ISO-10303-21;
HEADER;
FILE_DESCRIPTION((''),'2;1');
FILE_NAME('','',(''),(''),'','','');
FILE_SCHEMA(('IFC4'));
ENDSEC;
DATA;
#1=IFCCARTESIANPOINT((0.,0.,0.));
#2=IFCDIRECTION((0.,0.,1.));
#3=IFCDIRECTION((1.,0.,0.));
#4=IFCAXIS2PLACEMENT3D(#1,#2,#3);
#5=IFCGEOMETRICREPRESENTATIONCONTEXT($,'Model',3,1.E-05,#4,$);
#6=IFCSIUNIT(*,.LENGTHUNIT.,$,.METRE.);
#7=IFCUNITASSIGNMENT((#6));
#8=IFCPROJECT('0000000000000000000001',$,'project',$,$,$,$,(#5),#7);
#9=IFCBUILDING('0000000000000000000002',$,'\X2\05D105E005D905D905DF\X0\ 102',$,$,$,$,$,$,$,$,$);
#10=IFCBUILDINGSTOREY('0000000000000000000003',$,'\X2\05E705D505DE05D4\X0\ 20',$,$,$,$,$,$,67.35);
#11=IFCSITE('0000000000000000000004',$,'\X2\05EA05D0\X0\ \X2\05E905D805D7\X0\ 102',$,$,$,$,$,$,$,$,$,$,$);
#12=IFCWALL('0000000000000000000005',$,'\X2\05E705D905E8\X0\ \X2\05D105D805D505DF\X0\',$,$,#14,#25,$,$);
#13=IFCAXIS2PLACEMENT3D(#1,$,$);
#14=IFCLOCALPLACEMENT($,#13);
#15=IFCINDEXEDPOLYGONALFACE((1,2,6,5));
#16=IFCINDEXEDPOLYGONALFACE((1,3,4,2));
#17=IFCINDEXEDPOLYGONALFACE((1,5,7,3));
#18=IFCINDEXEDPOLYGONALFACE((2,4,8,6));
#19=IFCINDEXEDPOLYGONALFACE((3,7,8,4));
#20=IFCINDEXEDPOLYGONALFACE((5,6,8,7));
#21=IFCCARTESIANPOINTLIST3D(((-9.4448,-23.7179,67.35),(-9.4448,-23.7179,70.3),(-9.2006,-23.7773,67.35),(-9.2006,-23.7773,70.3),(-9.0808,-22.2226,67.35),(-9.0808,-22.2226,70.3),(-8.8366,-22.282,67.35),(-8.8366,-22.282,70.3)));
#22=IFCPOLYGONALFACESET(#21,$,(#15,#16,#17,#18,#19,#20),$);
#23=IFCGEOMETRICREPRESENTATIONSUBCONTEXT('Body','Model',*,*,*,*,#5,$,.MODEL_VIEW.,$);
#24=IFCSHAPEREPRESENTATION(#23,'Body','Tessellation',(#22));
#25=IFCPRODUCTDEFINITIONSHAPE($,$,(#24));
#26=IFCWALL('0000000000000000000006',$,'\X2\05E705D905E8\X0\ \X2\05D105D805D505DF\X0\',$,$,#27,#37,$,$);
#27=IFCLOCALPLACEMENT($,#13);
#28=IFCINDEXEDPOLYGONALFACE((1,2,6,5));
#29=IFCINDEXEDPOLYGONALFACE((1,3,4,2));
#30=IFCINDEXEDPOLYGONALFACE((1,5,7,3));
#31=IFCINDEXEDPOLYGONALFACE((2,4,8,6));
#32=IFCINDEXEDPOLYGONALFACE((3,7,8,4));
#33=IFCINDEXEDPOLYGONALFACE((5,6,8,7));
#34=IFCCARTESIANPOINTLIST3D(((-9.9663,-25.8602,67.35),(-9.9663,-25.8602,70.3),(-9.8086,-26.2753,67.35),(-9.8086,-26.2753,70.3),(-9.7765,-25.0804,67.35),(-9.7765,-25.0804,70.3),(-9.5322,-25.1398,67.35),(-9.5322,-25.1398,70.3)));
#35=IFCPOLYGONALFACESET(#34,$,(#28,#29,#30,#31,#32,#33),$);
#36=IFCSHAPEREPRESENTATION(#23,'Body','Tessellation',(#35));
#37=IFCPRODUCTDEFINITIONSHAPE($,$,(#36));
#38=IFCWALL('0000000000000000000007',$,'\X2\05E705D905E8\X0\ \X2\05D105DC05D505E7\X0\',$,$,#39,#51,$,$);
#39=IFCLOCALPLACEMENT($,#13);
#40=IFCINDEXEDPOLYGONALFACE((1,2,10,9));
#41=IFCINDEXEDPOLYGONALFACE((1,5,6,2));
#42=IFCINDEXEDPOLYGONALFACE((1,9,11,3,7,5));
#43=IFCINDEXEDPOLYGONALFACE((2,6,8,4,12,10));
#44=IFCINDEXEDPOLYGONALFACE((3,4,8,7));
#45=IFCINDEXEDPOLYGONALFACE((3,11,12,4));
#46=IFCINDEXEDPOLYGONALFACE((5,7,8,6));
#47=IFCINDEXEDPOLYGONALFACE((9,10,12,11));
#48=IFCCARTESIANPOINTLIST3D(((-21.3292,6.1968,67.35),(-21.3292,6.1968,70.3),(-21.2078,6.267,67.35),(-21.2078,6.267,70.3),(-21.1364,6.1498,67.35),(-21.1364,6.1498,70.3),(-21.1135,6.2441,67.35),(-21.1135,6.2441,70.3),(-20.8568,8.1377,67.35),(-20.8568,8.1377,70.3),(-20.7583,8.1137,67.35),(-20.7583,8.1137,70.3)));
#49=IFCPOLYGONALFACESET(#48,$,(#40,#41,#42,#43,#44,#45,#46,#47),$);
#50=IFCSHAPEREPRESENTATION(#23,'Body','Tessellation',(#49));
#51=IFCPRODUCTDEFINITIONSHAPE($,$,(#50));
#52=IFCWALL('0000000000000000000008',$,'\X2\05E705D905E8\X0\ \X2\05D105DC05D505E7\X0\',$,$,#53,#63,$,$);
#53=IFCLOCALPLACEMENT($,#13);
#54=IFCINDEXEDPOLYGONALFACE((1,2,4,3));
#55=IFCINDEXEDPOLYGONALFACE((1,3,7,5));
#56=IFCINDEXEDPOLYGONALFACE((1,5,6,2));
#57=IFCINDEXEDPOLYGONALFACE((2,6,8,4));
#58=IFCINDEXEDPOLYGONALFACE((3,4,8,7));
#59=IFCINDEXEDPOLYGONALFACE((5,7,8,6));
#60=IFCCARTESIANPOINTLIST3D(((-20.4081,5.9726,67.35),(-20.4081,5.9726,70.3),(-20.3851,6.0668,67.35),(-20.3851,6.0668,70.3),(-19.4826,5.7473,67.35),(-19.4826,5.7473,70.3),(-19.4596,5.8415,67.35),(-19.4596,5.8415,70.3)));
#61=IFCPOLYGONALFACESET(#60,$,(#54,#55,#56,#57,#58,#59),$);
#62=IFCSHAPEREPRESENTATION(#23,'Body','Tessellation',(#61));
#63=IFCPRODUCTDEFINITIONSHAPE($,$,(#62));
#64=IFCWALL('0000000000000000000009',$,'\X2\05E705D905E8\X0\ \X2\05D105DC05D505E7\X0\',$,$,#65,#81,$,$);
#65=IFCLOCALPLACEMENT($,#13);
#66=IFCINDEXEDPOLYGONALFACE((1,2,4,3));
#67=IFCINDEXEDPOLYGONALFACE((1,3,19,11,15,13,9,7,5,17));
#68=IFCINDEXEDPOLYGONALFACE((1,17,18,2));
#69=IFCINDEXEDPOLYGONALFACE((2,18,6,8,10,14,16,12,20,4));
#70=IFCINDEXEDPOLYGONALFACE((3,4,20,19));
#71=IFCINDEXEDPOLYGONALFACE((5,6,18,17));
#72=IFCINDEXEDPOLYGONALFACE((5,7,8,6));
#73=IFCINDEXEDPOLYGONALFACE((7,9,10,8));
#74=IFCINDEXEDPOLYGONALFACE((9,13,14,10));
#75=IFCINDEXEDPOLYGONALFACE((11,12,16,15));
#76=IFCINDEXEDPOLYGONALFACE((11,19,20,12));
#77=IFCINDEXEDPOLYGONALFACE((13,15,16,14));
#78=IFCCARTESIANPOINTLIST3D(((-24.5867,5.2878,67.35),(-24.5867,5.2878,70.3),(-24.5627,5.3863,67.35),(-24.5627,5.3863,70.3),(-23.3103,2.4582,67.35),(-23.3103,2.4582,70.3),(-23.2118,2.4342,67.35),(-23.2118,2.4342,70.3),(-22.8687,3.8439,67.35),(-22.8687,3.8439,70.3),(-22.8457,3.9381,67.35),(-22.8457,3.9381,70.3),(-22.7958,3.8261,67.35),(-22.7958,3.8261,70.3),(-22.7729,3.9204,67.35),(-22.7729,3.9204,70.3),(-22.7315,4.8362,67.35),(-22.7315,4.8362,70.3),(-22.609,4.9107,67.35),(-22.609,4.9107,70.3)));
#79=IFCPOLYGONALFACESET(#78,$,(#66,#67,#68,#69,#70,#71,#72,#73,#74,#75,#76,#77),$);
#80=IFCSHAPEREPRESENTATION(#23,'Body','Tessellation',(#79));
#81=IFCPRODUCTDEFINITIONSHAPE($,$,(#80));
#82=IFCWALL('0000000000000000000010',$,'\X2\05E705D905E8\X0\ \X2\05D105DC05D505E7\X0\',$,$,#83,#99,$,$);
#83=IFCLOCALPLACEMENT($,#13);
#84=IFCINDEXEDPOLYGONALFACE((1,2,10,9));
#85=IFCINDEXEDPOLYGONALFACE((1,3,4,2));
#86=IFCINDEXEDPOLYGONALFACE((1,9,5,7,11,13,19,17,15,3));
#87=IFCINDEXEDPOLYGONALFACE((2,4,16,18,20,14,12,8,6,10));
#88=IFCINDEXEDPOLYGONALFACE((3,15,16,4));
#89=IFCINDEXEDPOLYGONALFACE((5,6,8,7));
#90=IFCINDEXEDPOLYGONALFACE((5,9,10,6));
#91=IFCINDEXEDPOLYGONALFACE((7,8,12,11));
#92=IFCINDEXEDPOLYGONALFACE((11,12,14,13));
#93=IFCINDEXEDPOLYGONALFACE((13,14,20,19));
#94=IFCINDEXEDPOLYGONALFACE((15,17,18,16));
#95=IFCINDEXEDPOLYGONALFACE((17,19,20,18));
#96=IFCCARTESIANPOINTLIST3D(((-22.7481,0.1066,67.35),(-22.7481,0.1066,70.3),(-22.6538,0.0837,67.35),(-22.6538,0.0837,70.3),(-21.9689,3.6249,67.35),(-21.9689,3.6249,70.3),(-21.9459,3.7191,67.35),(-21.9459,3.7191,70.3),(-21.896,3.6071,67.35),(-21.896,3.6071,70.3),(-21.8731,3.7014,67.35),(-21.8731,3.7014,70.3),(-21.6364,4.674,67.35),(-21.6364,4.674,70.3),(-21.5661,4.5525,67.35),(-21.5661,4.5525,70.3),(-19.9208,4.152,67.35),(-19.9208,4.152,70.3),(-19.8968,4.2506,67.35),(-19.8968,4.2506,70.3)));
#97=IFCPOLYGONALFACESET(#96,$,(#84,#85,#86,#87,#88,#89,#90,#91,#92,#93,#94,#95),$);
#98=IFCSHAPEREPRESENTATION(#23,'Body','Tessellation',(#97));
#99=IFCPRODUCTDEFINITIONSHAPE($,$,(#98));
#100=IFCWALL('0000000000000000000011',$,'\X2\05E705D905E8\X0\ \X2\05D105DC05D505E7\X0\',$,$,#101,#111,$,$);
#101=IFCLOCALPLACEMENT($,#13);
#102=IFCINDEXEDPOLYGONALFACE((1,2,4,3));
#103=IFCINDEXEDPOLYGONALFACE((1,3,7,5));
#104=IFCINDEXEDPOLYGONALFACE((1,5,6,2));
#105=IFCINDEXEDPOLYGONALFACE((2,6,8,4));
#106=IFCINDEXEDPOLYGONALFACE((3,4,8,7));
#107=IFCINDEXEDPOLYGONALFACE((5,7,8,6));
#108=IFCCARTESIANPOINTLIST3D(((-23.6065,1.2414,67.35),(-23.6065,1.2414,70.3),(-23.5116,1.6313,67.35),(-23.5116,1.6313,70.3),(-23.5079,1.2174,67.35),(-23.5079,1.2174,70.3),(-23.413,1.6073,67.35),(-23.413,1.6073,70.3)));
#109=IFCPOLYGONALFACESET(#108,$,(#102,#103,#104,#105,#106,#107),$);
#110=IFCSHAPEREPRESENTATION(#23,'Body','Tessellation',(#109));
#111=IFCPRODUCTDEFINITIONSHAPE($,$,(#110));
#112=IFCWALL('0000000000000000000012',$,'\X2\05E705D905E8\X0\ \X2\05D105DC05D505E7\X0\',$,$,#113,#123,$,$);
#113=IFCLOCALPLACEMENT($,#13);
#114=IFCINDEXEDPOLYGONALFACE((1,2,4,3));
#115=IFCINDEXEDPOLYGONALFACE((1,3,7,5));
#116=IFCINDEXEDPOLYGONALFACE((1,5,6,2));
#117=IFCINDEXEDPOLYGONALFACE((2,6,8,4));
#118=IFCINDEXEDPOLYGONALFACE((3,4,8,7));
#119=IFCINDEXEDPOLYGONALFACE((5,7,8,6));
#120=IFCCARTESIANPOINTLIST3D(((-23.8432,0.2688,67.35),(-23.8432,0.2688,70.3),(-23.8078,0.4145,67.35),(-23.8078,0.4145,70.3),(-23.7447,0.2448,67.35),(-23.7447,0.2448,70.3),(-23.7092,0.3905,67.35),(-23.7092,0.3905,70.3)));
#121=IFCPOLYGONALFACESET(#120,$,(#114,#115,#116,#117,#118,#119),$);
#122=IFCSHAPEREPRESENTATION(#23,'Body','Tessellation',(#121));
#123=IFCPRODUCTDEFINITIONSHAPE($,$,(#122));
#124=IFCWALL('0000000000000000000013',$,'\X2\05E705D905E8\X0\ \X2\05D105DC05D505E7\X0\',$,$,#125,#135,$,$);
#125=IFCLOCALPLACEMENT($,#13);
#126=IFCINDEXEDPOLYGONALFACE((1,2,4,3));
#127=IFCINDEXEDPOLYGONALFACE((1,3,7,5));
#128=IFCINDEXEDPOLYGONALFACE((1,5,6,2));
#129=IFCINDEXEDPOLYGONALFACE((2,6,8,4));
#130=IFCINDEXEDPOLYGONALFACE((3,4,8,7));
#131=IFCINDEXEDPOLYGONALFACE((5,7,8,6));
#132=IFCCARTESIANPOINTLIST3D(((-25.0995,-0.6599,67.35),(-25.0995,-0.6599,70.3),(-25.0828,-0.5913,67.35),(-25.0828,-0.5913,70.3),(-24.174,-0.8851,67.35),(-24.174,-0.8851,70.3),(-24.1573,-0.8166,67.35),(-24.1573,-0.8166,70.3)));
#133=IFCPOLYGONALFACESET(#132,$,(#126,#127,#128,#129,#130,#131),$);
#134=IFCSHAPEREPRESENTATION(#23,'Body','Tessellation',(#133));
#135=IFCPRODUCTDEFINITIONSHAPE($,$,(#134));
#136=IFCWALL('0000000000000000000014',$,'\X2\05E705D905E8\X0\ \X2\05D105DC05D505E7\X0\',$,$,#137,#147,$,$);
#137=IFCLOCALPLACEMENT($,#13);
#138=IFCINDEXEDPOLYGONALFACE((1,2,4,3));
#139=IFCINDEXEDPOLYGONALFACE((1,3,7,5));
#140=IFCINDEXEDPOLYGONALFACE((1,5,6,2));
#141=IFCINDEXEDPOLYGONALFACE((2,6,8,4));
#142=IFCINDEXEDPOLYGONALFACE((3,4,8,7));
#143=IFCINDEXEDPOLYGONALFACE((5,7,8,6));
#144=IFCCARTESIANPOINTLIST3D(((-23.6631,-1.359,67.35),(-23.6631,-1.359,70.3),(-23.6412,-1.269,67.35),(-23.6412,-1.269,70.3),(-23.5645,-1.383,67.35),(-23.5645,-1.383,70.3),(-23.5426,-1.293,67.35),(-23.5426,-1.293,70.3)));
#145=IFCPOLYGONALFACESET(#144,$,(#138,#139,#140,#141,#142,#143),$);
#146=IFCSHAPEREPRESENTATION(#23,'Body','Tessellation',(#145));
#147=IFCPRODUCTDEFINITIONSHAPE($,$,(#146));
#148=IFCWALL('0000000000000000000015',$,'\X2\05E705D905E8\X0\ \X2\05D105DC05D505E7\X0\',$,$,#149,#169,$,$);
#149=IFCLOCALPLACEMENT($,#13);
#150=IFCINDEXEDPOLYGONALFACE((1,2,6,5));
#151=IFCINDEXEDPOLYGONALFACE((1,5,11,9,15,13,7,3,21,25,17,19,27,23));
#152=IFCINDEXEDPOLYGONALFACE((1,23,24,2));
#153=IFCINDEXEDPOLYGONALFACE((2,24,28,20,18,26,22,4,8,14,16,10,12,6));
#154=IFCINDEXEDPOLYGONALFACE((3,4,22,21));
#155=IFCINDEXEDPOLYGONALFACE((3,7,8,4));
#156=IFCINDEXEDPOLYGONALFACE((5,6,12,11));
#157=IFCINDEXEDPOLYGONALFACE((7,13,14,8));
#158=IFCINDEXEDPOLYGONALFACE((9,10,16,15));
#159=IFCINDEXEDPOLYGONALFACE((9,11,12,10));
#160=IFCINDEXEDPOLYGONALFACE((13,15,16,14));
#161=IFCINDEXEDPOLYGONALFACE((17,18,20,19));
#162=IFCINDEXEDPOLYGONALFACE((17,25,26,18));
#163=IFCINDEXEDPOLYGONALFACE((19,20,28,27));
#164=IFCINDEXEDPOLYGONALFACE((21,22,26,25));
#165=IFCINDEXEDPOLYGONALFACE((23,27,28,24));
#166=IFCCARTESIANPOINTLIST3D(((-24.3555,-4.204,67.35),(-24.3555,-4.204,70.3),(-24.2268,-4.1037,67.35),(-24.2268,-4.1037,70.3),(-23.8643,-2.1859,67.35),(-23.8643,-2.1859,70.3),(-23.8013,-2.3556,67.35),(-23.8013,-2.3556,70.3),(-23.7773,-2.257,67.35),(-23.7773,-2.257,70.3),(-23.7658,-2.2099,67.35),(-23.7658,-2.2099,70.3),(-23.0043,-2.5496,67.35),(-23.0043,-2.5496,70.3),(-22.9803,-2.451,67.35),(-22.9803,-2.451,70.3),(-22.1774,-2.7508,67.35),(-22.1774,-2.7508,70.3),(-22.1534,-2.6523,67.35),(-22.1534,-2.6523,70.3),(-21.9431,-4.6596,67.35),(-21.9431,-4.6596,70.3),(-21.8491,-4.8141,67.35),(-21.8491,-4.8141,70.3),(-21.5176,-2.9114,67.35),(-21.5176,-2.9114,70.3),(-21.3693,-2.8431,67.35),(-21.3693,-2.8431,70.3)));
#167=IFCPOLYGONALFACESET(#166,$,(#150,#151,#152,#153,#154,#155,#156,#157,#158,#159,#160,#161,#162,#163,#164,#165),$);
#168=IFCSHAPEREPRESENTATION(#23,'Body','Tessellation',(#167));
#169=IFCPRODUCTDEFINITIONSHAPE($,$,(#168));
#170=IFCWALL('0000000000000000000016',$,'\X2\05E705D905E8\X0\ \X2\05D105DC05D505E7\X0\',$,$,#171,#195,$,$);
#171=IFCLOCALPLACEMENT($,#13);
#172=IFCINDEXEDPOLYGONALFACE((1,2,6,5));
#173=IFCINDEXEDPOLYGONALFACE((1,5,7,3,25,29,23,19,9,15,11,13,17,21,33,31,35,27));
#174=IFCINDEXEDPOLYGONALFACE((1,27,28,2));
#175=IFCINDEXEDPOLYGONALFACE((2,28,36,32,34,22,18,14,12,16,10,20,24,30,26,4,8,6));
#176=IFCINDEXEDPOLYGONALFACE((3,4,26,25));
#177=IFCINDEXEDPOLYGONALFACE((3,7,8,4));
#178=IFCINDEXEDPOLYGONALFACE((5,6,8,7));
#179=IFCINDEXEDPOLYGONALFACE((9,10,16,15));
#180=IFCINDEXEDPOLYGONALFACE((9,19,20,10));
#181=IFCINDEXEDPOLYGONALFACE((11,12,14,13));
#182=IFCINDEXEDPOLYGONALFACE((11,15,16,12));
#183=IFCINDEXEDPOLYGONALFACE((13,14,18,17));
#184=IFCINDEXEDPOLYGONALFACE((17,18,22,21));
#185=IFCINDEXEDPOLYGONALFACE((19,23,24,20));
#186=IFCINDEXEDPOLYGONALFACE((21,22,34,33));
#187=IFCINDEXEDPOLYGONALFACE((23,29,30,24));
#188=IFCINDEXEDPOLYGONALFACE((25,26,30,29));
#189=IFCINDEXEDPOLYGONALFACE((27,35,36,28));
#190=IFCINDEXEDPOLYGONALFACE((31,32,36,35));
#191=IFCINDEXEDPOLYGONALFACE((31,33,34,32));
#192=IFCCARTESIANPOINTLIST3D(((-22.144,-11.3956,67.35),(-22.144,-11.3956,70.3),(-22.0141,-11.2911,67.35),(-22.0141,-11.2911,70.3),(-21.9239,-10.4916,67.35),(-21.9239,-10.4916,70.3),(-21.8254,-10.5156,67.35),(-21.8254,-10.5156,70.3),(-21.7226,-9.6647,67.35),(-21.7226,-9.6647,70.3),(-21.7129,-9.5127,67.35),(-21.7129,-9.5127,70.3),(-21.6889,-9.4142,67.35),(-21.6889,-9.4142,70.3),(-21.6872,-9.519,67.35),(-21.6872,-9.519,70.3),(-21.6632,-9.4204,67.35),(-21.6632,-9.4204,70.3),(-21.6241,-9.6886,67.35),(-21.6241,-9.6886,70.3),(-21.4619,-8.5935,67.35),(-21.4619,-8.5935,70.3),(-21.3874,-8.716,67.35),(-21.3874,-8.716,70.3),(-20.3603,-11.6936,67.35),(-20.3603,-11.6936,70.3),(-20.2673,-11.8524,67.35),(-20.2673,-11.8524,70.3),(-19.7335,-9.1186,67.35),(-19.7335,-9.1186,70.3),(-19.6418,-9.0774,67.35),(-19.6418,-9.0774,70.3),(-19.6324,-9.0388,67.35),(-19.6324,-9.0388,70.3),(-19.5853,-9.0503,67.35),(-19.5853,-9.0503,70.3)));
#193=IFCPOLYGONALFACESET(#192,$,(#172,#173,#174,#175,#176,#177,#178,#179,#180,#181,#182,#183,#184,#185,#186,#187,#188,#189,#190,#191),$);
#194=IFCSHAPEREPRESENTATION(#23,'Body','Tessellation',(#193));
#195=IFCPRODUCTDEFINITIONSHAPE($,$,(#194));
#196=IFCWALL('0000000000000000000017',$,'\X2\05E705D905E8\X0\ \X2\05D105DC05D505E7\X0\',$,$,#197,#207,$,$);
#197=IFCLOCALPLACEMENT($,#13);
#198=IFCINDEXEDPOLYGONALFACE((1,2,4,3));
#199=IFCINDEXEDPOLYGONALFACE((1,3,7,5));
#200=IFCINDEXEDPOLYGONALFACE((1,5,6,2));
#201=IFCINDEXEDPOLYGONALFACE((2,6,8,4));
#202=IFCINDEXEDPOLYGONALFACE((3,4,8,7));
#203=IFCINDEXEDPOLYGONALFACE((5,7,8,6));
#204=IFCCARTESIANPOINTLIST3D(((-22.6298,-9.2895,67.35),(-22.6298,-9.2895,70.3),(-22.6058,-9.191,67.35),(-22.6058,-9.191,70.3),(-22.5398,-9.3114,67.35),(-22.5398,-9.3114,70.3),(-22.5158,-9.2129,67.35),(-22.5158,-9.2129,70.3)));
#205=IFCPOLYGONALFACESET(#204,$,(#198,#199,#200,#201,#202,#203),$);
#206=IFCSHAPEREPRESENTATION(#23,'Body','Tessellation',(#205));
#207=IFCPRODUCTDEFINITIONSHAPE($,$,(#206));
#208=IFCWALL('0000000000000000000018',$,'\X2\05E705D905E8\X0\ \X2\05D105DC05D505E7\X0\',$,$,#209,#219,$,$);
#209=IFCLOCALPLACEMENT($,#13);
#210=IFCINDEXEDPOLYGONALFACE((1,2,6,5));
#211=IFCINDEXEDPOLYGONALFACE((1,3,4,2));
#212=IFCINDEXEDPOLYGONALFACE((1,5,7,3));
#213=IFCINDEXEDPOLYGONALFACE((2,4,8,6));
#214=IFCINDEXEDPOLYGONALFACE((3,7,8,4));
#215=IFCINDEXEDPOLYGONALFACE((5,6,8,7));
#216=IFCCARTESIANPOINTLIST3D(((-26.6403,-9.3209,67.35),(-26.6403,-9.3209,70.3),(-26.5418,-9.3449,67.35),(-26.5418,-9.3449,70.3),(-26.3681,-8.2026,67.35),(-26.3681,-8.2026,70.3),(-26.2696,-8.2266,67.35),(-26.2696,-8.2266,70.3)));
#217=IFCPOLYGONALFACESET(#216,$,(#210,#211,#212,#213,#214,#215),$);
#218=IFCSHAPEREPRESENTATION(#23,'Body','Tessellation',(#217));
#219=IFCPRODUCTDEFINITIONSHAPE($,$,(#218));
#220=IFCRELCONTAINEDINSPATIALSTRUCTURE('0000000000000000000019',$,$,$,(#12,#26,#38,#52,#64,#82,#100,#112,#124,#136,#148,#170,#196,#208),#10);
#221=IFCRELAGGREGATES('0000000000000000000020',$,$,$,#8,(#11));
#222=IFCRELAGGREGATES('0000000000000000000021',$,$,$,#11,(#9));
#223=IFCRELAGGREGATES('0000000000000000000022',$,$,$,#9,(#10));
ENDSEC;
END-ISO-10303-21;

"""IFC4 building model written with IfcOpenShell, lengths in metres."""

from ifc_helpers import new_model, si_unit, frame, origin_with_axes, context, subcontext, project, spatial, polyline, outline, extrude, element, save


model = new_model("IFC4")

# Units and contexts
model_context = context("Model", 3, precision=1e-05, world=origin_with_axes())
body_context = subcontext(model_context, "Body", "Model", "MODEL_VIEW")
ifc_project = project(units=[si_unit("LENGTHUNIT", "METRE")], contexts=[model_context])

# Site, building, storey
site = spatial("IfcSite", under=ifc_project, Name="תא שטח 102")
building = spatial("IfcBuilding", under=site, Name="בניין 102")
storey = spatial("IfcBuildingStorey", under=building, Name="קומה 20", Elevation=67.35)

# Walls
element("IfcWall", 1, inside=storey, Name="קיר בטון", context=body_context, shape_type="SweptSolid", body=[
    extrude(outline(polyline([(-9.4448, -23.7179), (-9.2006, -23.7773), (-8.8366, -22.282), (-9.0808, -22.2226), (-9.4448, -23.7179)])), frame((0.0, 0.0, 67.35)), (0.0, 0.0, 1.0), 2.95),
])
element("IfcWall", 2, inside=storey, Name="קיר בטון", context=body_context, shape_type="SweptSolid", body=[
    extrude(outline(polyline([(-9.9663, -25.8602), (-9.8086, -26.2753), (-9.5322, -25.1398), (-9.7765, -25.0804), (-9.9663, -25.8602)])), frame((0.0, 0.0, 67.35)), (0.0, 0.0, 1.0), 2.95),
])
element("IfcWall", 3, inside=storey, Name="קיר בלוק", context=body_context, shape_type="SweptSolid", body=[
    extrude(outline(polyline([(-21.1135, 6.2441), (-21.2078, 6.267), (-20.7583, 8.1137), (-20.8568, 8.1377), (-21.3292, 6.1968), (-21.1364, 6.1498), (-21.1135, 6.2441)])), frame((0.0, 0.0, 67.35)), (0.0, 0.0, 1.0), 2.95),
])
element("IfcWall", 4, inside=storey, Name="קיר בלוק", context=body_context, shape_type="SweptSolid", body=[
    extrude(outline(polyline([(-19.4596, 5.8415), (-20.3851, 6.0668), (-20.4081, 5.9726), (-19.4826, 5.7473), (-19.4596, 5.8415)])), frame((0.0, 0.0, 67.35)), (0.0, 0.0, 1.0), 2.95),
])
element("IfcWall", 5, inside=storey, Name="קיר בלוק", context=body_context, shape_type="SweptSolid", body=[
    extrude(outline(polyline([(-23.3103, 2.4582), (-23.2118, 2.4342), (-22.8687, 3.8439), (-22.7958, 3.8261), (-22.7729, 3.9204), (-22.8457, 3.9381), (-22.609, 4.9107), (-24.5627, 5.3863), (-24.5867, 5.2878), (-22.7315, 4.8362), (-23.3103, 2.4582)])), frame((0.0, 0.0, 67.35)), (0.0, 0.0, 1.0), 2.95),
])
element("IfcWall", 6, inside=storey, Name="קיר בלוק", context=body_context, shape_type="SweptSolid", body=[
    extrude(outline(polyline([(-21.9689, 3.6249), (-21.896, 3.6071), (-22.7481, 0.1066), (-22.6538, 0.0837), (-21.5661, 4.5525), (-19.9208, 4.152), (-19.8968, 4.2506), (-21.6364, 4.674), (-21.8731, 3.7014), (-21.9459, 3.7191), (-21.9689, 3.6249)])), frame((0.0, 0.0, 67.35)), (0.0, 0.0, 1.0), 2.95),
])
element("IfcWall", 7, inside=storey, Name="קיר בלוק", context=body_context, shape_type="SweptSolid", body=[
    extrude(outline(polyline([(-23.413, 1.6073), (-23.5116, 1.6313), (-23.6065, 1.2414), (-23.5079, 1.2174), (-23.413, 1.6073)])), frame((0.0, 0.0, 67.35)), (0.0, 0.0, 1.0), 2.95),
])
element("IfcWall", 8, inside=storey, Name="קיר בלוק", context=body_context, shape_type="SweptSolid", body=[
    extrude(outline(polyline([(-23.8078, 0.4145), (-23.8432, 0.2688), (-23.7447, 0.2448), (-23.7092, 0.3905), (-23.8078, 0.4145)])), frame((0.0, 0.0, 67.35)), (0.0, 0.0, 1.0), 2.95),
])
element("IfcWall", 9, inside=storey, Name="קיר בלוק", context=body_context, shape_type="SweptSolid", body=[
    extrude(outline(polyline([(-25.0828, -0.5913), (-25.0995, -0.6599), (-24.174, -0.8851), (-24.1573, -0.8166), (-25.0828, -0.5913)])), frame((0.0, 0.0, 67.35)), (0.0, 0.0, 1.0), 2.95),
])
element("IfcWall", 10, inside=storey, Name="קיר בלוק", context=body_context, shape_type="SweptSolid", body=[
    extrude(outline(polyline([(-23.5426, -1.293), (-23.6412, -1.269), (-23.6631, -1.359), (-23.5645, -1.383), (-23.5426, -1.293)])), frame((0.0, 0.0, 67.35)), (0.0, 0.0, 1.0), 2.95),
])
element("IfcWall", 11, inside=storey, Name="קיר בלוק", context=body_context, shape_type="SweptSolid", body=[
    extrude(outline(polyline([(-24.2268, -4.1037), (-23.8013, -2.3556), (-23.0043, -2.5496), (-22.9803, -2.451), (-23.7773, -2.257), (-23.7658, -2.2099), (-23.8643, -2.1859), (-24.3555, -4.204), (-21.8491, -4.8141), (-21.3693, -2.8431), (-22.1534, -2.6523), (-22.1774, -2.7508), (-21.5176, -2.9114), (-21.9431, -4.6596), (-24.2268, -4.1037)])), frame((0.0, 0.0, 67.35)), (0.0, 0.0, 1.0), 2.95),
])
element("IfcWall", 12, inside=storey, Name="קיר בלוק", context=body_context, shape_type="SweptSolid", body=[
    extrude(outline(polyline([(-21.7129, -9.5127), (-21.6872, -9.519), (-21.7226, -9.6647), (-21.6241, -9.6886), (-21.3874, -8.716), (-19.7335, -9.1186), (-20.3603, -11.6936), (-22.0141, -11.2911), (-21.8254, -10.5156), (-21.9239, -10.4916), (-22.144, -11.3956), (-20.2673, -11.8524), (-19.5853, -9.0503), (-19.6418, -9.0774), (-19.6324, -9.0388), (-21.4619, -8.5935), (-21.6632, -9.4204), (-21.6889, -9.4142), (-21.7129, -9.5127)])), frame((0.0, 0.0, 67.35)), (0.0, 0.0, 1.0), 2.95),
])
element("IfcWall", 13, inside=storey, Name="קיר בלוק", context=body_context, shape_type="SweptSolid", body=[
    extrude(outline(polyline([(-22.6058, -9.191), (-22.6298, -9.2895), (-22.5398, -9.3114), (-22.5158, -9.2129), (-22.6058, -9.191)])), frame((0.0, 0.0, 67.35)), (0.0, 0.0, 1.0), 2.95),
])
element("IfcWall", 14, inside=storey, Name="קיר בלוק", context=body_context, shape_type="SweptSolid", body=[
    extrude(outline(polyline([(-26.6403, -9.3209), (-26.5418, -9.3449), (-26.2696, -8.2266), (-26.3681, -8.2026), (-26.6403, -9.3209)])), frame((0.0, 0.0, 67.35)), (0.0, 0.0, 1.0), 2.95),
])

save(model, "model.ifc")
